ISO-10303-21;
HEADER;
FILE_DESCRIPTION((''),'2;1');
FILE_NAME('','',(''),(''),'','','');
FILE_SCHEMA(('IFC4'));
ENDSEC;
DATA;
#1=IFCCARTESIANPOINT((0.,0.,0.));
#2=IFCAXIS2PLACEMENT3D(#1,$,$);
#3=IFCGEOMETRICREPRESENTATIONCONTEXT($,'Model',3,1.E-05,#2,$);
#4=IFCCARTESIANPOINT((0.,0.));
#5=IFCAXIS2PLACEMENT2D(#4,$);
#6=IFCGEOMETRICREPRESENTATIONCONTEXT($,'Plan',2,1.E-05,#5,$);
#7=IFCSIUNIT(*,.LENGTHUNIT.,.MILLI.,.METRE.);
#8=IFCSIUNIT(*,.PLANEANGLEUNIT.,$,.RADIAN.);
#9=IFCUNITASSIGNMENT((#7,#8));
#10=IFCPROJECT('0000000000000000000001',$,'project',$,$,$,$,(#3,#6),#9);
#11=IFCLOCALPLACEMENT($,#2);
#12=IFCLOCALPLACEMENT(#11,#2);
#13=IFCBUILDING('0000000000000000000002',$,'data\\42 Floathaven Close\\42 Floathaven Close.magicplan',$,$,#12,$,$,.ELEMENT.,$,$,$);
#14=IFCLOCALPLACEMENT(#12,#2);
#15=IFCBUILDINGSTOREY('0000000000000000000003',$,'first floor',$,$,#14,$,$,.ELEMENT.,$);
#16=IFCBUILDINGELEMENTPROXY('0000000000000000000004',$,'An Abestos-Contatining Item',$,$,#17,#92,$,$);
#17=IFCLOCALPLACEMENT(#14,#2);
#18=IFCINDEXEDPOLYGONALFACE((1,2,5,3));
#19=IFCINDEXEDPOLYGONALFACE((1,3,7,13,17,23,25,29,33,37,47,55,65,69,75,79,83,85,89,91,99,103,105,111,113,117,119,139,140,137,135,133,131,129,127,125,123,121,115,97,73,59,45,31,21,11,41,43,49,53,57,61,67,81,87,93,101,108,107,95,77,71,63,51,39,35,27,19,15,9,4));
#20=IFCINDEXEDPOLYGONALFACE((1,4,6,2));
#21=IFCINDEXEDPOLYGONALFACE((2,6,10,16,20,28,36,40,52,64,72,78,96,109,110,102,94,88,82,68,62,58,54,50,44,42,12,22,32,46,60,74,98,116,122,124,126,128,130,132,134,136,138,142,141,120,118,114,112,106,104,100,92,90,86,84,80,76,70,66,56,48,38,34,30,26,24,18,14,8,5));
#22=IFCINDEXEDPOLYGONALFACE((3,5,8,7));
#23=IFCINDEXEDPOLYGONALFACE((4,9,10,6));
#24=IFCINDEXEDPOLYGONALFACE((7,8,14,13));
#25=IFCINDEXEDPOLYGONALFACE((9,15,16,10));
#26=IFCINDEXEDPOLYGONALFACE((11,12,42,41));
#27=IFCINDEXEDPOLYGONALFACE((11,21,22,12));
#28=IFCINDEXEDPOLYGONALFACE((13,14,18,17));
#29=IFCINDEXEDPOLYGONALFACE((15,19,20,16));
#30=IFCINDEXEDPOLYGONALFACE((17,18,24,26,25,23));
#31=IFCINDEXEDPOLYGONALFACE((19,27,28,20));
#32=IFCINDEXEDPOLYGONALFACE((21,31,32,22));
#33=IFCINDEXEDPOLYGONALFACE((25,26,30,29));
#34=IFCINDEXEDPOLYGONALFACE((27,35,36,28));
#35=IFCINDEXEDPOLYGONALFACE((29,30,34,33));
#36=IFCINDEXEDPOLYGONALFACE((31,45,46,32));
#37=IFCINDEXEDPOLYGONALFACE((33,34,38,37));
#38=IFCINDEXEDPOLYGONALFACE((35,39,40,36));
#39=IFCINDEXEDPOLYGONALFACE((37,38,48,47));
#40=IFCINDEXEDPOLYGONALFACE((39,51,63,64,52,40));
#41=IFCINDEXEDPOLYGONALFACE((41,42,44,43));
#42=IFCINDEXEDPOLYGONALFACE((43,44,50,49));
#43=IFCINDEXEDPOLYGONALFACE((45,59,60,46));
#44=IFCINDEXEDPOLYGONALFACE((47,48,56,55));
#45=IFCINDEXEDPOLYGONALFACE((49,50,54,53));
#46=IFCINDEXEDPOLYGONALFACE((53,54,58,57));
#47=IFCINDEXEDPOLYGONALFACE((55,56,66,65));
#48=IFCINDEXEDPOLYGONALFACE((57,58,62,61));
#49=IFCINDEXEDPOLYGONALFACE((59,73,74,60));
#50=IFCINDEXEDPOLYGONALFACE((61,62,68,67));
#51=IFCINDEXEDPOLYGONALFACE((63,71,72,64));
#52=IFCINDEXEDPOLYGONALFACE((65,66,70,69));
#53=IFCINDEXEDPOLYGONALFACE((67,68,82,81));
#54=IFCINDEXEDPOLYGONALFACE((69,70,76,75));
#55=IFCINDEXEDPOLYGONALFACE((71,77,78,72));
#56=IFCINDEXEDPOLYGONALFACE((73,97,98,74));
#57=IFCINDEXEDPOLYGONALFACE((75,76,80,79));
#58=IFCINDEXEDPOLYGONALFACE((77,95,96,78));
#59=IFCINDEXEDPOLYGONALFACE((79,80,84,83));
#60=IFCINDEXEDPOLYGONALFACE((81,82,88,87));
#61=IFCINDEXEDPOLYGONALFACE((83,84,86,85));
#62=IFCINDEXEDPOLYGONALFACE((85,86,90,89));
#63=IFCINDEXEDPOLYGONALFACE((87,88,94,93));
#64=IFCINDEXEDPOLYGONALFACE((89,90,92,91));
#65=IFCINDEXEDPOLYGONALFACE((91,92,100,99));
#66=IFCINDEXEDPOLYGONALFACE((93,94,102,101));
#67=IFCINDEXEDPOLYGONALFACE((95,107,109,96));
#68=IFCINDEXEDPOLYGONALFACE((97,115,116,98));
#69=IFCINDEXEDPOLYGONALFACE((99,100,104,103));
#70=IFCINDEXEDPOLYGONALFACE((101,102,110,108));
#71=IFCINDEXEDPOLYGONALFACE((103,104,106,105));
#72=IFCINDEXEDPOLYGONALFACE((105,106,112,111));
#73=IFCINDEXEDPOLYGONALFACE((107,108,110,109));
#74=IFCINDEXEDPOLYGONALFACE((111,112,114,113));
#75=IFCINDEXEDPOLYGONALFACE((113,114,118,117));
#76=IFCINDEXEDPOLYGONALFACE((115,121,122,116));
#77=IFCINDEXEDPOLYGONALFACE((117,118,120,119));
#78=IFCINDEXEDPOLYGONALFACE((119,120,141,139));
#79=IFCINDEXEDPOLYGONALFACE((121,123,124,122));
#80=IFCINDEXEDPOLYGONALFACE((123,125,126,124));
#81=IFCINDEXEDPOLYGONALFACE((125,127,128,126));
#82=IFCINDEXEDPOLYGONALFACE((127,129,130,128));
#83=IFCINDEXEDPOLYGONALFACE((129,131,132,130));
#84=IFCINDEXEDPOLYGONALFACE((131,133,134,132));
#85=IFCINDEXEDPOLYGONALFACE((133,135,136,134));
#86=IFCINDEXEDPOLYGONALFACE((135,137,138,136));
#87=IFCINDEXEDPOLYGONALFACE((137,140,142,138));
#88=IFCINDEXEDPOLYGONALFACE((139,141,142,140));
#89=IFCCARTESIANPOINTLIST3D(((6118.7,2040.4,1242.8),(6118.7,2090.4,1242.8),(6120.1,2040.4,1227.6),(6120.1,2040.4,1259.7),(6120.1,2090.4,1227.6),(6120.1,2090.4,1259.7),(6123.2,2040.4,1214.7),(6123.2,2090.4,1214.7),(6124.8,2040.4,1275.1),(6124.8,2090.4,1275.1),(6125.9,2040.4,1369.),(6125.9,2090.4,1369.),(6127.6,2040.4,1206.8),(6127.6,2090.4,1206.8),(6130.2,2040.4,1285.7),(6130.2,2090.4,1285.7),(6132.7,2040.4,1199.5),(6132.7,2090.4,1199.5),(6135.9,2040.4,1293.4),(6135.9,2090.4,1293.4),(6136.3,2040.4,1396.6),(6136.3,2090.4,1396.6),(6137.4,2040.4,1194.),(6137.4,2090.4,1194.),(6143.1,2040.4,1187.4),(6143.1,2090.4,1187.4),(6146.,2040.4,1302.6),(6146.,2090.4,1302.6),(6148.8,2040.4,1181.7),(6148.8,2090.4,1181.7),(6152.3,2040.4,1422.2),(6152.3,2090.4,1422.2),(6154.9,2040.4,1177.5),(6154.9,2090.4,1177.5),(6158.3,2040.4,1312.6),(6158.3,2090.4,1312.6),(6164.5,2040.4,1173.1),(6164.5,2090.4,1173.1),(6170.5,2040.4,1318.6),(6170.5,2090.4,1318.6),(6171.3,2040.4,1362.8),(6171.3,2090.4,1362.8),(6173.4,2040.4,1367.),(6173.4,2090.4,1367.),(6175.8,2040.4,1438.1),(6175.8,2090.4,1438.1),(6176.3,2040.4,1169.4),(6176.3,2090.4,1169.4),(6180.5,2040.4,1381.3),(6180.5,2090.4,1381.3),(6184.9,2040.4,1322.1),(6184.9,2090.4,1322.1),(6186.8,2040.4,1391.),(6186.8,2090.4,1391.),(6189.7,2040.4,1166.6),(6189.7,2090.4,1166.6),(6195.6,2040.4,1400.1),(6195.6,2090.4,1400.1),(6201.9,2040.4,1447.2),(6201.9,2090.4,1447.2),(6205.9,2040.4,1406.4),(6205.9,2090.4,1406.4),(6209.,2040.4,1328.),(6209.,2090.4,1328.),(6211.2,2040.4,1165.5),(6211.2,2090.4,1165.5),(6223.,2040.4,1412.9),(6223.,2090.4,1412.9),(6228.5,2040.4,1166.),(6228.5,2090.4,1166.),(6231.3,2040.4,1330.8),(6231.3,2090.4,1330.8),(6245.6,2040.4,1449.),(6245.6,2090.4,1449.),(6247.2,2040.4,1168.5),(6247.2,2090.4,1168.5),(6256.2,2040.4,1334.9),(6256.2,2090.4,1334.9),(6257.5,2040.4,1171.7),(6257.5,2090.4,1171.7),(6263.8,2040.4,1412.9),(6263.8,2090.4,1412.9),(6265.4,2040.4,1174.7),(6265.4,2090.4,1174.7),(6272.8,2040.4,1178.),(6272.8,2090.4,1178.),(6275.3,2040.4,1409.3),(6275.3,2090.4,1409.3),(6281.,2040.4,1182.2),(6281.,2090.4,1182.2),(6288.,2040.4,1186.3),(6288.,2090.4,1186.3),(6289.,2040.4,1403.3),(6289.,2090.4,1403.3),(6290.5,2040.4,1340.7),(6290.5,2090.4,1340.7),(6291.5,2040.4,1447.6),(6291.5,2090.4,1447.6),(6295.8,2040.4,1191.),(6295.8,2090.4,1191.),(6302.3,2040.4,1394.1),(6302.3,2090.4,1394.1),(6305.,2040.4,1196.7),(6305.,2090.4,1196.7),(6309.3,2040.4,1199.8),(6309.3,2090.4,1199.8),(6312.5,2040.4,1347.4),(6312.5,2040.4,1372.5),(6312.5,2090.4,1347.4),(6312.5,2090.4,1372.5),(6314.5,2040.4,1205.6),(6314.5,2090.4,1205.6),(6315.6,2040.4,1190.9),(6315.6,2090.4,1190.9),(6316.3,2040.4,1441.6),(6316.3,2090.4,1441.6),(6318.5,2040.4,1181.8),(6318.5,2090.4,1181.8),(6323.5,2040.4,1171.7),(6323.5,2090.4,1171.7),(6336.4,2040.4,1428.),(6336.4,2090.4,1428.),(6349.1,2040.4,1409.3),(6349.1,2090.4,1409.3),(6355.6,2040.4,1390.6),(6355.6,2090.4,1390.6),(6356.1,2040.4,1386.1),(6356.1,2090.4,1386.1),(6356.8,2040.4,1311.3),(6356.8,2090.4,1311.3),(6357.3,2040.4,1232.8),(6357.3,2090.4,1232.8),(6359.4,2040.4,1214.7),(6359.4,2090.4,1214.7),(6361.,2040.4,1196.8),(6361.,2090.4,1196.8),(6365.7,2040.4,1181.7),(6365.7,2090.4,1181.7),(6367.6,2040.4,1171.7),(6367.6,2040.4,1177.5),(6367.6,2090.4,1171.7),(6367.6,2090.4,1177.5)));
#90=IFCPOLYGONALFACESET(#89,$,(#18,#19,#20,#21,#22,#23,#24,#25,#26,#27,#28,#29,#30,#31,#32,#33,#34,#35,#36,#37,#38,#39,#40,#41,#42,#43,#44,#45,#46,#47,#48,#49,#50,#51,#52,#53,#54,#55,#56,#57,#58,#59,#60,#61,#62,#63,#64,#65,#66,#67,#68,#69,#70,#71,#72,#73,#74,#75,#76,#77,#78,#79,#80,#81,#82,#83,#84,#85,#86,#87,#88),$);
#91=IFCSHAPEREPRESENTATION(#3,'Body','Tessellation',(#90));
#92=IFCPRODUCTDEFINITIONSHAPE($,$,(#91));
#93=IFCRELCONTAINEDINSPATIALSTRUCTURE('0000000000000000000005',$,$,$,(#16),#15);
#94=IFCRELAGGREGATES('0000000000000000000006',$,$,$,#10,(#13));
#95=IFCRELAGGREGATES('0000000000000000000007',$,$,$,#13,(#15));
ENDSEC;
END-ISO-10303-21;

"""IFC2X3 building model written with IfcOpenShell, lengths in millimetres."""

from ifc_helpers import new_model, si_unit, frame, origin, origin_2d, place, context, project, spatial, polyline, outline, extrude, element, save


model = new_model("IFC2X3")

# Units and contexts
model_context = context("Model", 3, precision=1e-05, world=origin())
plan_context = context("Plan", 2, precision=1e-05, world=origin_2d())
ifc_project = project(units=[si_unit("LENGTHUNIT", "METRE", prefix="MILLI"), si_unit("PLANEANGLEUNIT", "RADIAN")], contexts=[model_context, plan_context])

# Building, storey
placement_1 = place(None, origin())
building_placement = place(placement_1, origin())
building = spatial("IfcBuilding", under=ifc_project, at=building_placement, Name="data\\42 Floathaven Close\\42 Floathaven Close.magicplan", CompositionType="ELEMENT")
storey_placement = place(building_placement, origin())
storey = spatial("IfcBuildingStorey", under=building, at=storey_placement, Name="first floor", CompositionType="ELEMENT")

# Building element proxy
placement_2 = place(None, frame((8065.2, 856.2, 0.0)))
proxy_1_placement = place(placement_2, frame((-1947.6, 1234.2, 1165.0)))
element("IfcBuildingElementProxy", 1, at=proxy_1_placement, inside=storey, Name="An Abestos-Contatining Item", context=model_context, shape_type="SurfaceModel", body=[
    extrude(outline(polyline([(239.2, 0.0, 146.3), (239.7, 0.0, 67.8), (241.8, 0.0, 49.7), (243.3, 0.0, 31.9), (248.1, 0.0, 16.7), (250.0, 0.0, 12.5), (250.0, 0.0, 6.7), (205.8, 0.0, 6.7), (200.9, 0.0, 16.8), (197.9, 0.0, 25.9), (196.9, 0.0, 40.6), (191.6, 0.0, 34.8), (187.3, 0.0, 31.7), (178.2, 0.0, 26.0), (170.3, 0.0, 21.3), (163.4, 0.0, 17.2), (155.2, 0.0, 13.0), (147.8, 0.0, 9.7), (139.9, 0.0, 6.7), (129.5, 0.0, 3.5), (110.9, 0.0, 1.0), (93.6, 0.0, 0.5), (72.1, 0.0, 1.6), (58.6, 0.0, 4.4), (46.9, 0.0, 8.1), (37.3, 0.0, 12.5), (31.2, 0.0, 16.7), (25.4, 0.0, 22.4), (19.8, 0.0, 29.0), (15.1, 0.0, 34.5), (9.9, 0.0, 41.9), (5.5, 0.0, 49.7), (2.5, 0.0, 62.6), (1.0, 0.0, 77.8), (2.5, 0.0, 94.7), (7.2, 0.0, 110.1), (12.6, 0.0, 120.7), (18.2, 0.0, 128.4), (28.4, 0.0, 137.6), (40.7, 0.0, 147.6), (52.9, 0.0, 153.6), (67.3, 0.0, 157.1), (91.3, 0.0, 163.0), (113.7, 0.0, 165.8), (138.6, 0.0, 169.9), (172.9, 0.0, 175.7), (194.8, 0.0, 182.4), (194.8, 0.0, 207.5), (184.7, 0.0, 229.1), (171.3, 0.0, 238.3), (157.6, 0.0, 244.3), (146.2, 0.0, 247.9), (105.3, 0.0, 247.9), (88.3, 0.0, 241.4), (77.9, 0.0, 235.1), (69.1, 0.0, 226.0), (62.9, 0.0, 216.3), (55.7, 0.0, 202.0), (53.6, 0.0, 197.8), (8.2, 0.0, 204.0), (18.7, 0.0, 231.7), (34.6, 0.0, 257.2), (58.1, 0.0, 273.1), (84.2, 0.0, 282.2), (128.0, 0.0, 284.0), (173.9, 0.0, 282.6), (198.6, 0.0, 276.6), (218.8, 0.0, 263.1), (231.4, 0.0, 244.3), (238.0, 0.0, 225.6), (238.5, 0.0, 221.1)]), holes=[polyline([(193.0, 0.0, 144.2), (193.0, 0.0, 117.7), (190.5, 0.0, 97.8), (183.8, 0.0, 80.4), (174.2, 0.0, 64.5), (165.3, 0.0, 54.4), (152.5, 0.0, 47.3), (138.0, 0.0, 41.5), (124.6, 0.0, 37.8), (85.5, 0.0, 37.8), (75.0, 0.0, 41.4), (65.8, 0.0, 47.1), (57.8, 0.0, 55.4), (52.1, 0.0, 66.4), (49.5, 0.0, 74.4), (49.5, 0.0, 88.6), (55.3, 0.0, 100.7), (65.3, 0.0, 109.9), (81.0, 0.0, 119.8), (101.0, 0.0, 125.3), (119.9, 0.0, 128.5), (146.8, 0.0, 131.5), (165.0, 0.0, 134.9), (179.8, 0.0, 140.1), (193.0, 0.0, 144.2)])], kind="CURVE"), origin(), (0.0, -1.0, 0.0), 50.0),
])

save(model, "model.ifc")
